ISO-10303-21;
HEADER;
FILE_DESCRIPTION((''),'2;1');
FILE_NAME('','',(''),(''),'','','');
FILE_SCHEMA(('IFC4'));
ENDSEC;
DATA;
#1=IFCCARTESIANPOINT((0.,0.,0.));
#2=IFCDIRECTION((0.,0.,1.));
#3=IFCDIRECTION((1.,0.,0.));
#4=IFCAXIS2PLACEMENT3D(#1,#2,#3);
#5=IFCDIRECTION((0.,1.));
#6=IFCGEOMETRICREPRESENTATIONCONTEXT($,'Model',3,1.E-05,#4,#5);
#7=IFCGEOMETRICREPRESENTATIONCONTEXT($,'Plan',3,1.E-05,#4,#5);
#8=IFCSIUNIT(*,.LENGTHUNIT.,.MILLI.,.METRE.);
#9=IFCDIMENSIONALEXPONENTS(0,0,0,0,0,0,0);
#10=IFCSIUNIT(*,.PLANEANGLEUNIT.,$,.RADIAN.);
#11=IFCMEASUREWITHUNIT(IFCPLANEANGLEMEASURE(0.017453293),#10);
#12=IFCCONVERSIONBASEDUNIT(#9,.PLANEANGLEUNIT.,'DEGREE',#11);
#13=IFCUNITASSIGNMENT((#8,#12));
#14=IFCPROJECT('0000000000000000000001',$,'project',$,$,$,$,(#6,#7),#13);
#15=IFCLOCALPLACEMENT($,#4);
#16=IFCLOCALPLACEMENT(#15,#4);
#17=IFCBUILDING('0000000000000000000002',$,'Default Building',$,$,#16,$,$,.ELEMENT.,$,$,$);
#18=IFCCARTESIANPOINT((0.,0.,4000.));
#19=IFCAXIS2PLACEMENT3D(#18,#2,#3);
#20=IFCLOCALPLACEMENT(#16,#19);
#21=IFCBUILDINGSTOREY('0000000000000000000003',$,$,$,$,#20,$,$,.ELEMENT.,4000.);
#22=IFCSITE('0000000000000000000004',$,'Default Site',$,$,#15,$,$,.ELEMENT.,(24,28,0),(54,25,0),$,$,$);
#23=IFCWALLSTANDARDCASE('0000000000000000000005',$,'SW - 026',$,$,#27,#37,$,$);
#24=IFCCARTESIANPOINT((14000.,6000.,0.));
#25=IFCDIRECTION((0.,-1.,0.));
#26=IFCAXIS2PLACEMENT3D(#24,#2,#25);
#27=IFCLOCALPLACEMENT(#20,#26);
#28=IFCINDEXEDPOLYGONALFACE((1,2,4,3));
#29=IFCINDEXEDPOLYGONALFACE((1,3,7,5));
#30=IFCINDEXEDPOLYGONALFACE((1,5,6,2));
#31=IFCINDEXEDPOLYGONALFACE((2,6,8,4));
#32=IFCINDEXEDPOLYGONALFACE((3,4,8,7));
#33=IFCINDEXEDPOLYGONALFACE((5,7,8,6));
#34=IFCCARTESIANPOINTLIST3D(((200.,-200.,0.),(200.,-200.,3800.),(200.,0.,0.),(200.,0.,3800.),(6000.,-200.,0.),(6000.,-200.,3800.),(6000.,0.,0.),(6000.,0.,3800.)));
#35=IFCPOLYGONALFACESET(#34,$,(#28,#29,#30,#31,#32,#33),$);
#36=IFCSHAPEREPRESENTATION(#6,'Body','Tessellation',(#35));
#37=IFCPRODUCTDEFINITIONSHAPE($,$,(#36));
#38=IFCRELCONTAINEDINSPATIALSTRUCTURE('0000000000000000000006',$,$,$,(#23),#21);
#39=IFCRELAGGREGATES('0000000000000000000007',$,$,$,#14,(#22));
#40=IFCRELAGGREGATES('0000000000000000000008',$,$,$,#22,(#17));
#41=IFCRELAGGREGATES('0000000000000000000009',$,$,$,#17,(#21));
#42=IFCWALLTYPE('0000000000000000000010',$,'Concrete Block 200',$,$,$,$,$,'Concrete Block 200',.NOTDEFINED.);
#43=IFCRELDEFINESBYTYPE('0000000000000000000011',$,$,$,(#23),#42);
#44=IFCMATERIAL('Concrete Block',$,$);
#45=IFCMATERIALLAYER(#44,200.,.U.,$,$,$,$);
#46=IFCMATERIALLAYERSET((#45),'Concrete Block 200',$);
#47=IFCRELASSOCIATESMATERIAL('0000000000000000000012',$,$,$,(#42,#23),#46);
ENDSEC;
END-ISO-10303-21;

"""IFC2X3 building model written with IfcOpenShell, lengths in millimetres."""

from ifc_helpers import new_model, entity, si_unit, converted_unit, direction, frame, origin_with_axes, place, context, project, spatial, polyline, outline, extrude, material, layer, layer_set, layer_usage, type_object, element, save


model = new_model("IFC2X3")

# Units and contexts
model_context = context("Model", 3, precision=1e-05, world=origin_with_axes(), true_north=direction((0.0, 1.0)))
plan_context = context("Plan", 3, precision=1e-05, world=origin_with_axes(), true_north=direction((0.0, 1.0)))
ifc_project = project(units=[si_unit("LENGTHUNIT", "METRE", prefix="MILLI"), converted_unit("PLANEANGLEUNIT", "DEGREE", entity("IfcPlaneAngleMeasure", 0.017453293), si_unit("PLANEANGLEUNIT", "RADIAN"), dimensions=[0, 0, 0, 0, 0, 0, 0])], contexts=[model_context, plan_context])

# Site, building, storey
site_placement = place(None, origin_with_axes())
site = spatial("IfcSite", under=ifc_project, at=site_placement, Name="Default Site", CompositionType="ELEMENT", RefLatitude=(24, 28, 0), RefLongitude=(54, 25, 0))
building_placement = place(site_placement, origin_with_axes())
building = spatial("IfcBuilding", under=site, at=building_placement, Name="Default Building", CompositionType="ELEMENT")
storey_placement = place(building_placement, frame((0.0, 0.0, 4000.0), z_axis=(0.0, 0.0, 1.0), x_axis=(1.0, 0.0, 0.0)))
storey = spatial("IfcBuildingStorey", under=building, at=storey_placement, CompositionType="ELEMENT", Elevation=4000.0)

# Shared definitions
ifc_material = material(Name="Concrete Block")
ifc_layer = layer(ifc_material, 200.0, ventilated="UNKNOWN")
ifc_layer_set = layer_set([ifc_layer], Name="Concrete Block 200")

# Wall
wall_type = type_object("IfcWallType", Name="Concrete Block 200", ElementType="Concrete Block 200", PredefinedType="NOTDEFINED", material=ifc_layer_set)
ifc_layer_usage_1 = layer_usage(ifc_layer_set, "AXIS2", "NEGATIVE", 0.0)
wall_1_placement = place(storey_placement, frame((14000.0, 6000.0, 0.0), z_axis=(0.0, 0.0, 1.0), x_axis=(0.0, -1.0, 0.0)))
element("IfcWallStandardCase", 1, at=wall_1_placement, inside=storey, type_object=wall_type, material=ifc_layer_usage_1, Name="SW - 026", context=model_context, shape_type="SweptSolid", body=[
    extrude(outline(polyline([(200.0, -200.0), (6000.0, -200.0), (6000.0, 0.0), (200.0, 0.0), (200.0, -200.0)])), origin_with_axes(), (0.0, 0.0, 1.0), 3800.0),
])

save(model, "model.ifc")
